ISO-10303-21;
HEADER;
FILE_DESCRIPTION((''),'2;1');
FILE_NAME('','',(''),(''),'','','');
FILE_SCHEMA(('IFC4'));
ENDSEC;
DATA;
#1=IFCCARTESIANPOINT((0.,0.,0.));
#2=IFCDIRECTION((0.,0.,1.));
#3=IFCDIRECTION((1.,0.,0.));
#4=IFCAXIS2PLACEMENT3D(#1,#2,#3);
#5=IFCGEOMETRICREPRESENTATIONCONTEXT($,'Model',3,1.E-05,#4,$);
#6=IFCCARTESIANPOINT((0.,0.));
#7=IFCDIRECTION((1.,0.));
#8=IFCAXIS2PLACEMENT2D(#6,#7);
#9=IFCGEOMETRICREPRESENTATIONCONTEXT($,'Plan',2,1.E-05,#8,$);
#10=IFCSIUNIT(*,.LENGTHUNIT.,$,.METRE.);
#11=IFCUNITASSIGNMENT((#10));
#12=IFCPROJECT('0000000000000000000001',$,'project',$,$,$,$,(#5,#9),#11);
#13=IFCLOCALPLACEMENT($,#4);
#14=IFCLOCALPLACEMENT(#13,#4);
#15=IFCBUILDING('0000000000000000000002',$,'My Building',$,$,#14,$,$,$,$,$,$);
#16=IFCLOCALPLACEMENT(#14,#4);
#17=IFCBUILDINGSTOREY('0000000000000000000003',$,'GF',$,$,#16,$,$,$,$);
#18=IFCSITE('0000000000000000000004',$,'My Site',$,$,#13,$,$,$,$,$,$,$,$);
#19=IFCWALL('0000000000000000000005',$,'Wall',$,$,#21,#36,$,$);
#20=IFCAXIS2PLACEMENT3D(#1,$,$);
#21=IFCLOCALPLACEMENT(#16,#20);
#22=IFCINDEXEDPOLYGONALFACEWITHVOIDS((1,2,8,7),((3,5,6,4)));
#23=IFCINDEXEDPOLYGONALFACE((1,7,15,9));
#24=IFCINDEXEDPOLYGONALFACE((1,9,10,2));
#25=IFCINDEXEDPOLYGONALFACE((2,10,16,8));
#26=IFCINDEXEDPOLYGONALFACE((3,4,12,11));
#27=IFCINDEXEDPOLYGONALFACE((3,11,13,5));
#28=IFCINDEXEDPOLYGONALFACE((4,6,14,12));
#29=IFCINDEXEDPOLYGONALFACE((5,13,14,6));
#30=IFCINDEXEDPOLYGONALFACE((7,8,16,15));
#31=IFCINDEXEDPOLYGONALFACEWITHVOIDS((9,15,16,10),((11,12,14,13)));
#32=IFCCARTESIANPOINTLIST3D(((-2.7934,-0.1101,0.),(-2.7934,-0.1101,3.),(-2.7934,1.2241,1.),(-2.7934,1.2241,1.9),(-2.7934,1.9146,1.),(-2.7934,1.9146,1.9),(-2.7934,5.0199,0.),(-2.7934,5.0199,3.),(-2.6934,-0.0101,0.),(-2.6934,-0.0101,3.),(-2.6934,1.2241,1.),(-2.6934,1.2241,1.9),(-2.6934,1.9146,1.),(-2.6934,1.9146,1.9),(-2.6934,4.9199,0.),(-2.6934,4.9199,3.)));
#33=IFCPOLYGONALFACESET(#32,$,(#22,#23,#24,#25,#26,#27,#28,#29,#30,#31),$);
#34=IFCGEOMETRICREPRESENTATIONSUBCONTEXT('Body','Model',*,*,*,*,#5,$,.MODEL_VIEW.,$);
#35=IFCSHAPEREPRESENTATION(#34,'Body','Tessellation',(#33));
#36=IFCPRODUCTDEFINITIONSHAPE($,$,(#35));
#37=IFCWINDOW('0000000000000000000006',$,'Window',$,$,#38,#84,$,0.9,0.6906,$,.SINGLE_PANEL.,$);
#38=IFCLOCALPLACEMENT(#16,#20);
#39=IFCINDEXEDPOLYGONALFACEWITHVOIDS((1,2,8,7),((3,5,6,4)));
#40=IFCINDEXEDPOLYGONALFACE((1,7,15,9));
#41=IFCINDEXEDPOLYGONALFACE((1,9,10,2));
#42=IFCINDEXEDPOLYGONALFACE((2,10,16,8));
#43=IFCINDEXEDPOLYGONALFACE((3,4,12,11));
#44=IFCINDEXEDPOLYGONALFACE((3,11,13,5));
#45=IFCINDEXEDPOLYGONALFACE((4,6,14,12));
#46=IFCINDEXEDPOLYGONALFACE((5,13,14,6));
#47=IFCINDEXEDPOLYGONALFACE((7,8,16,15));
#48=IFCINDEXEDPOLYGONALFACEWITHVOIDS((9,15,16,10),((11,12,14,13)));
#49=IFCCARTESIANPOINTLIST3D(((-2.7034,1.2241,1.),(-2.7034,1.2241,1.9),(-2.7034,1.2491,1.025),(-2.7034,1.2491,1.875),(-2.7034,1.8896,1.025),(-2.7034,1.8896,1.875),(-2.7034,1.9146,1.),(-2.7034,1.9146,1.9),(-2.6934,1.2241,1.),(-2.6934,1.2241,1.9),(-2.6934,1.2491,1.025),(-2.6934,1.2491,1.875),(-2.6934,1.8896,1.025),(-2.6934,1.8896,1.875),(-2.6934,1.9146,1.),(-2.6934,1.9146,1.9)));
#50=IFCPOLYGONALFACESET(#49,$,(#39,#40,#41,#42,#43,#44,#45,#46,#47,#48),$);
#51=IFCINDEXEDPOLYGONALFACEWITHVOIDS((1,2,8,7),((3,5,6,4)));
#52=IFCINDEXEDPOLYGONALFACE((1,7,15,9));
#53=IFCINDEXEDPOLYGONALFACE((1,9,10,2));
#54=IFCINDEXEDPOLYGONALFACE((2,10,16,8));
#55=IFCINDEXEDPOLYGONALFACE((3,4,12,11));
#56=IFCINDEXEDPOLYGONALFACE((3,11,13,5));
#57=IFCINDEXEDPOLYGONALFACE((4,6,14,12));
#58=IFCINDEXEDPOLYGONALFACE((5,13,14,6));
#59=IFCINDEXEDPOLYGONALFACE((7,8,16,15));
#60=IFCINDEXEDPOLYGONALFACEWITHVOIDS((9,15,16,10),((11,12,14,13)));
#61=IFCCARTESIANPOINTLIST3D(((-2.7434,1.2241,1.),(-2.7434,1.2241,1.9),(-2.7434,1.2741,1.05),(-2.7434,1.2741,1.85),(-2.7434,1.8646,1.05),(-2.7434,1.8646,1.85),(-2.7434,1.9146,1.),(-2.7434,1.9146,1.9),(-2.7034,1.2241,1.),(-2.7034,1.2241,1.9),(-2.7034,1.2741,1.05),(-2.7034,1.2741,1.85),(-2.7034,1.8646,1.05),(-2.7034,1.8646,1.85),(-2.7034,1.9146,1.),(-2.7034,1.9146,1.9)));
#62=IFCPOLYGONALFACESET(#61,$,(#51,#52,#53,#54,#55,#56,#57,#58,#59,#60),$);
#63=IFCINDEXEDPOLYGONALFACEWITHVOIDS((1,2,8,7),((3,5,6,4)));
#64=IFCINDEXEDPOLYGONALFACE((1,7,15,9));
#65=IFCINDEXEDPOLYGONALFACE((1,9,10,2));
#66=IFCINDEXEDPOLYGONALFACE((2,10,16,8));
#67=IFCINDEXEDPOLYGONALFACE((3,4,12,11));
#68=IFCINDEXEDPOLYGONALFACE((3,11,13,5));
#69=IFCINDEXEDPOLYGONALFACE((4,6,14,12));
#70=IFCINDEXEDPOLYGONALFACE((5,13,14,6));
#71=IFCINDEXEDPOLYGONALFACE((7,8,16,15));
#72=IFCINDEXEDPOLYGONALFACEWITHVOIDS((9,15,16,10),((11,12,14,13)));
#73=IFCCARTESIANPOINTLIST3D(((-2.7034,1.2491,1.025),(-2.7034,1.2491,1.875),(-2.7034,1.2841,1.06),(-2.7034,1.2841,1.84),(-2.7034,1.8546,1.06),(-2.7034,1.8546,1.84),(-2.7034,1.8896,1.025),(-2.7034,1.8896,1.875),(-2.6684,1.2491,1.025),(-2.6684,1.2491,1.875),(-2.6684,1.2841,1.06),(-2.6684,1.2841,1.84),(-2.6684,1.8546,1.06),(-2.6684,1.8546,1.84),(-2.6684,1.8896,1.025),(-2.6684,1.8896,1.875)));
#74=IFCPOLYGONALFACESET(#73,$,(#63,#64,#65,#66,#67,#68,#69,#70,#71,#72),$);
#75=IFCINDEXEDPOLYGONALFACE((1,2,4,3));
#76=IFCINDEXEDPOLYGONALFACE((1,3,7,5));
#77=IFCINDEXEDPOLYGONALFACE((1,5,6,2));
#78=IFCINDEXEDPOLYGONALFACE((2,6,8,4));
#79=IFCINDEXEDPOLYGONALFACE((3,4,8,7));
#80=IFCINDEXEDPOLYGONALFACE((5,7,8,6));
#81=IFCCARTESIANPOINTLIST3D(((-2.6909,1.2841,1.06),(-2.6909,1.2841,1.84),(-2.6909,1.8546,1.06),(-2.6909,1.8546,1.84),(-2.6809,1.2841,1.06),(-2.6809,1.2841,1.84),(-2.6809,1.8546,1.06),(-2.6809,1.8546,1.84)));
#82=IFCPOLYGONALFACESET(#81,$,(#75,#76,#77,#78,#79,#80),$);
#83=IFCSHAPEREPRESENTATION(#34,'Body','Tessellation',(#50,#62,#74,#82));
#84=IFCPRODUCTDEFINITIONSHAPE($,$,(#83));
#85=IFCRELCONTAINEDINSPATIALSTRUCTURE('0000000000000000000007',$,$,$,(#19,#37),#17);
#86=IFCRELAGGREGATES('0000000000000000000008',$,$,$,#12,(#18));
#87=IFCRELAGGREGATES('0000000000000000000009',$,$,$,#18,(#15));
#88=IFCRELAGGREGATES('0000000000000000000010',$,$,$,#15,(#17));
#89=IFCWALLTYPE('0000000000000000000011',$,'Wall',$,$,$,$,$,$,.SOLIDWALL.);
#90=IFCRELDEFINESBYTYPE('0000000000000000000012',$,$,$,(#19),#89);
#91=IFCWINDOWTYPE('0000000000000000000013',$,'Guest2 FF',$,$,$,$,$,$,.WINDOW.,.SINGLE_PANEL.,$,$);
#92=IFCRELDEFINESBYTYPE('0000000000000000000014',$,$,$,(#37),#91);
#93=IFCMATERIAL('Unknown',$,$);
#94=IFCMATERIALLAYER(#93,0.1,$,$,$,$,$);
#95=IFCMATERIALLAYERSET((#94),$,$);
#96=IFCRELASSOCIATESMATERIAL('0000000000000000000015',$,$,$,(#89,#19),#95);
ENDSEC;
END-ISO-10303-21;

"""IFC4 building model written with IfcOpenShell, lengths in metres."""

from ifc_helpers import new_model, entity, si_unit, frame, origin_with_axes, origin_2d_with_axis, place, context, subcontext, project, spatial, line, indexed_curve, outline, extrude, shape, source, transform, mapped, material, layer, layer_set, layer_usage, type_object, type_shapes, element, fill, save


model = new_model("IFC4")

# Units and contexts
model_context = context("Model", 3, precision=1e-05, world=origin_with_axes())
plan_context = context("Plan", 2, precision=1e-05, world=origin_2d_with_axis())
body_context_1 = subcontext(model_context, "Body", "Model", "MODEL_VIEW")
body_context_2 = subcontext(plan_context, "Body", "Plan", "PLAN_VIEW")
ifc_project = project(units=[si_unit("LENGTHUNIT", "METRE")], contexts=[model_context, plan_context])

# Site, building, storey
site_placement = place(None, origin_with_axes())
site = spatial("IfcSite", under=ifc_project, at=site_placement, Name="My Site")
building_placement = place(site_placement, origin_with_axes())
building = spatial("IfcBuilding", under=site, at=building_placement, Name="My Building")
storey_placement = place(building_placement, origin_with_axes())
storey = spatial("IfcBuildingStorey", under=building, at=storey_placement, Name="GF")

# Shared definitions
ifc_material = material(Name="Unknown")

# Shared definitions
ifc_layer_1 = layer(ifc_material, 0.1)
ifc_layer_set_1 = layer_set([ifc_layer_1])
wall_type = type_object("IfcWallType", Name="Wall", PredefinedType="SOLIDWALL", material=ifc_layer_set_1)

# Wall, opening, window
ifc_layer_usage_1 = layer_usage(ifc_layer_set_1, "AXIS2", "POSITIVE", 0.0)
wall_1_placement = place(storey_placement, frame((-2.7934, 5.0199, 0.0), z_axis=(0.0, 0.0, 1.0), x_axis=(0.0, -1.0, 0.0)))
wall_1 = element("IfcWall", 1, at=wall_1_placement, inside=storey, type_object=wall_type, material=ifc_layer_usage_1, Name="Wall", context=body_context_1, shape_type="SweptSolid", body=[
    extrude(outline(indexed_curve([(0.0, 0.0), (0.1, 0.1), (5.03, 0.1), (5.13, 0.0)], segments=[line(1, 2, 3, 4, 1)])), origin_with_axes(), (0.0, 0.0, 1.0), 3.0),
])
shared_shape_1 = source(origin_with_axes(), body_context_1, "Body", "SweptSolid", [
    extrude(outline(indexed_curve([(0.0, 0.0), (0.6906, 0.0), (0.6906, 0.9), (0.0, 0.9)], segments=[line(1, 2, 3, 4, 1)])), frame((0.0, -0.6, 0.0), z_axis=(0.0, -1.0, 0.0), x_axis=(1.0, 0.0, 0.0)), (0.0, 0.0, -1.0), 1.2),
])
opening_1_placement = place(wall_1_placement, frame((3.1053, 0.0, 1.0), z_axis=(0.0, 0.0, 1.0), x_axis=(1.0, 0.0, 0.0)))
opening_1 = element("IfcOpeningElement", 2, at=opening_1_placement, cuts=wall_1, PredefinedType="OPENING", context=body_context_1, shape_type="MappedRepresentation", body=[
    mapped(shared_shape_1, transform((0.0, 0.0, 0.0), x_axis=(1.0, 0.0, 0.0), y_axis=(0.0, 1.0, 0.0), z_axis=(0.0, 0.0, 1.0), scale=1.0)),
])
window_type_1 = type_object("IfcWindowType", Name="Guest2 FF", PartitioningType="SINGLE_PANEL", PredefinedType="WINDOW")
shared_shape_2 = source(origin_with_axes(), body_context_1, "Body", "SweptSolid", [
    extrude(outline(indexed_curve([(0.0, 0.0), (0.6906, 0.0), (0.6906, 0.9), (0.0, 0.9)], segments=[line(1, 2, 3, 4, 1)]), holes=[indexed_curve([(0.025, 0.025), (0.6656, 0.025), (0.6656, 0.875), (0.025, 0.875)], segments=[line(1, 2, 3, 4, 1)])]), frame((0.0, 0.09, 0.0), z_axis=(0.0, -1.0, 0.0), x_axis=(1.0, 0.0, 0.0)), (0.0, 0.0, -1.0), 0.01),
    extrude(outline(indexed_curve([(0.0, 0.0), (0.6906, 0.0), (0.6906, 0.9), (0.0, 0.9)], segments=[line(1, 2, 3, 4, 1)]), holes=[indexed_curve([(0.05, 0.05), (0.6406, 0.05), (0.6406, 0.85), (0.05, 0.85)], segments=[line(1, 2, 3, 4, 1)])]), frame((0.0, 0.05, 0.0), z_axis=(0.0, -1.0, 0.0), x_axis=(1.0, 0.0, 0.0)), (0.0, 0.0, -1.0), 0.04),
    extrude(outline(indexed_curve([(0.0, 0.0), (0.6406, 0.0), (0.6406, 0.85), (0.0, 0.85)], segments=[line(1, 2, 3, 4, 1)]), holes=[indexed_curve([(0.035, 0.035), (0.6056, 0.035), (0.6056, 0.815), (0.035, 0.815)], segments=[line(1, 2, 3, 4, 1)])]), frame((0.025, 0.09, 0.025), z_axis=(0.0, -1.0, 0.0), x_axis=(1.0, 0.0, 0.0)), (0.0, 0.0, -1.0), 0.035),
    extrude(outline(indexed_curve([(0.035, 0.035), (0.6056, 0.035), (0.6056, 0.815), (0.035, 0.815)], segments=[line(1, 2, 3, 4, 1)])), frame((0.025, 0.1025, 0.025), z_axis=(0.0, -1.0, 0.0), x_axis=(1.0, 0.0, 0.0)), (0.0, 0.0, -1.0), 0.01),
])
shared_shape_3 = source(origin_with_axes(), body_context_2, "Body", "Curve2D", [
    entity("IfcIndexedPolyCurve", entity("IfcCartesianPointList2D", [[0.05, 0.05], [0.6406, 0.05]])),
    entity("IfcIndexedPolyCurve", entity("IfcCartesianPointList2D", [[0.0, 0.1], [0.025, 0.1], [0.025, 0.09], [0.05, 0.09], [0.05, 0.05], [0.0, 0.05]]), [entity("IfcLineIndex", [1, 2, 3, 4, 5, 6, 1])]),
    entity("IfcIndexedPolyCurve", entity("IfcCartesianPointList2D", [[0.6906, 0.1], [0.6656, 0.1], [0.6656, 0.09], [0.6406, 0.09], [0.6406, 0.05], [0.6906, 0.05]]), [entity("IfcLineIndex", [1, 2, 3, 4, 5, 6, 1])]),
    entity("IfcIndexedPolyCurve", entity("IfcCartesianPointList2D", [[0.025, 0.09], [0.06, 0.09], [0.06, 0.125], [0.025, 0.125]]), [entity("IfcLineIndex", [1, 2, 3, 4, 1])]),
    entity("IfcIndexedPolyCurve", entity("IfcCartesianPointList2D", [[0.6656, 0.09], [0.6306, 0.09], [0.6306, 0.125], [0.6656, 0.125]]), [entity("IfcLineIndex", [1, 2, 3, 4, 1])]),
    entity("IfcIndexedPolyCurve", entity("IfcCartesianPointList2D", [[0.06, 0.09], [0.6306, 0.09]])),
    entity("IfcIndexedPolyCurve", entity("IfcCartesianPointList2D", [[0.06, 0.125], [0.6306, 0.125]])),
    entity("IfcIndexedPolyCurve", entity("IfcCartesianPointList2D", [[0.06, 0.1075], [0.6306, 0.1075]])),
])
type_shapes(window_type_1, [shared_shape_2, shared_shape_3])
window_1_placement = place(opening_1_placement, frame((0.0, 0.0, 0.0), z_axis=(0.0, 0.0, 1.0), x_axis=(1.0, 0.0, 0.0)))
window_1 = element("IfcWindow", 3, at=window_1_placement, inside=storey, type_object=window_type_1, Name="Window", OverallHeight=0.9, OverallWidth=0.6906, PartitioningType="SINGLE_PANEL", shapes=[
    shape(body_context_1, "Body", "MappedRepresentation", [mapped(shared_shape_2, transform((0.0, 0.0, 0.0), x_axis=(1.0, 0.0, 0.0), y_axis=(0.0, 1.0, 0.0), z_axis=(0.0, 0.0, 1.0), scale=1.0))]),
    shape(body_context_2, "Body", "MappedRepresentation", [mapped(shared_shape_3, transform((0.0, 0.0, 0.0), x_axis=(1.0, 0.0, 0.0), y_axis=(0.0, 1.0, 0.0), z_axis=(0.0, 0.0, 1.0), scale=1.0))]),
])
fill(opening_1, window_1)

save(model, "model.ifc")
